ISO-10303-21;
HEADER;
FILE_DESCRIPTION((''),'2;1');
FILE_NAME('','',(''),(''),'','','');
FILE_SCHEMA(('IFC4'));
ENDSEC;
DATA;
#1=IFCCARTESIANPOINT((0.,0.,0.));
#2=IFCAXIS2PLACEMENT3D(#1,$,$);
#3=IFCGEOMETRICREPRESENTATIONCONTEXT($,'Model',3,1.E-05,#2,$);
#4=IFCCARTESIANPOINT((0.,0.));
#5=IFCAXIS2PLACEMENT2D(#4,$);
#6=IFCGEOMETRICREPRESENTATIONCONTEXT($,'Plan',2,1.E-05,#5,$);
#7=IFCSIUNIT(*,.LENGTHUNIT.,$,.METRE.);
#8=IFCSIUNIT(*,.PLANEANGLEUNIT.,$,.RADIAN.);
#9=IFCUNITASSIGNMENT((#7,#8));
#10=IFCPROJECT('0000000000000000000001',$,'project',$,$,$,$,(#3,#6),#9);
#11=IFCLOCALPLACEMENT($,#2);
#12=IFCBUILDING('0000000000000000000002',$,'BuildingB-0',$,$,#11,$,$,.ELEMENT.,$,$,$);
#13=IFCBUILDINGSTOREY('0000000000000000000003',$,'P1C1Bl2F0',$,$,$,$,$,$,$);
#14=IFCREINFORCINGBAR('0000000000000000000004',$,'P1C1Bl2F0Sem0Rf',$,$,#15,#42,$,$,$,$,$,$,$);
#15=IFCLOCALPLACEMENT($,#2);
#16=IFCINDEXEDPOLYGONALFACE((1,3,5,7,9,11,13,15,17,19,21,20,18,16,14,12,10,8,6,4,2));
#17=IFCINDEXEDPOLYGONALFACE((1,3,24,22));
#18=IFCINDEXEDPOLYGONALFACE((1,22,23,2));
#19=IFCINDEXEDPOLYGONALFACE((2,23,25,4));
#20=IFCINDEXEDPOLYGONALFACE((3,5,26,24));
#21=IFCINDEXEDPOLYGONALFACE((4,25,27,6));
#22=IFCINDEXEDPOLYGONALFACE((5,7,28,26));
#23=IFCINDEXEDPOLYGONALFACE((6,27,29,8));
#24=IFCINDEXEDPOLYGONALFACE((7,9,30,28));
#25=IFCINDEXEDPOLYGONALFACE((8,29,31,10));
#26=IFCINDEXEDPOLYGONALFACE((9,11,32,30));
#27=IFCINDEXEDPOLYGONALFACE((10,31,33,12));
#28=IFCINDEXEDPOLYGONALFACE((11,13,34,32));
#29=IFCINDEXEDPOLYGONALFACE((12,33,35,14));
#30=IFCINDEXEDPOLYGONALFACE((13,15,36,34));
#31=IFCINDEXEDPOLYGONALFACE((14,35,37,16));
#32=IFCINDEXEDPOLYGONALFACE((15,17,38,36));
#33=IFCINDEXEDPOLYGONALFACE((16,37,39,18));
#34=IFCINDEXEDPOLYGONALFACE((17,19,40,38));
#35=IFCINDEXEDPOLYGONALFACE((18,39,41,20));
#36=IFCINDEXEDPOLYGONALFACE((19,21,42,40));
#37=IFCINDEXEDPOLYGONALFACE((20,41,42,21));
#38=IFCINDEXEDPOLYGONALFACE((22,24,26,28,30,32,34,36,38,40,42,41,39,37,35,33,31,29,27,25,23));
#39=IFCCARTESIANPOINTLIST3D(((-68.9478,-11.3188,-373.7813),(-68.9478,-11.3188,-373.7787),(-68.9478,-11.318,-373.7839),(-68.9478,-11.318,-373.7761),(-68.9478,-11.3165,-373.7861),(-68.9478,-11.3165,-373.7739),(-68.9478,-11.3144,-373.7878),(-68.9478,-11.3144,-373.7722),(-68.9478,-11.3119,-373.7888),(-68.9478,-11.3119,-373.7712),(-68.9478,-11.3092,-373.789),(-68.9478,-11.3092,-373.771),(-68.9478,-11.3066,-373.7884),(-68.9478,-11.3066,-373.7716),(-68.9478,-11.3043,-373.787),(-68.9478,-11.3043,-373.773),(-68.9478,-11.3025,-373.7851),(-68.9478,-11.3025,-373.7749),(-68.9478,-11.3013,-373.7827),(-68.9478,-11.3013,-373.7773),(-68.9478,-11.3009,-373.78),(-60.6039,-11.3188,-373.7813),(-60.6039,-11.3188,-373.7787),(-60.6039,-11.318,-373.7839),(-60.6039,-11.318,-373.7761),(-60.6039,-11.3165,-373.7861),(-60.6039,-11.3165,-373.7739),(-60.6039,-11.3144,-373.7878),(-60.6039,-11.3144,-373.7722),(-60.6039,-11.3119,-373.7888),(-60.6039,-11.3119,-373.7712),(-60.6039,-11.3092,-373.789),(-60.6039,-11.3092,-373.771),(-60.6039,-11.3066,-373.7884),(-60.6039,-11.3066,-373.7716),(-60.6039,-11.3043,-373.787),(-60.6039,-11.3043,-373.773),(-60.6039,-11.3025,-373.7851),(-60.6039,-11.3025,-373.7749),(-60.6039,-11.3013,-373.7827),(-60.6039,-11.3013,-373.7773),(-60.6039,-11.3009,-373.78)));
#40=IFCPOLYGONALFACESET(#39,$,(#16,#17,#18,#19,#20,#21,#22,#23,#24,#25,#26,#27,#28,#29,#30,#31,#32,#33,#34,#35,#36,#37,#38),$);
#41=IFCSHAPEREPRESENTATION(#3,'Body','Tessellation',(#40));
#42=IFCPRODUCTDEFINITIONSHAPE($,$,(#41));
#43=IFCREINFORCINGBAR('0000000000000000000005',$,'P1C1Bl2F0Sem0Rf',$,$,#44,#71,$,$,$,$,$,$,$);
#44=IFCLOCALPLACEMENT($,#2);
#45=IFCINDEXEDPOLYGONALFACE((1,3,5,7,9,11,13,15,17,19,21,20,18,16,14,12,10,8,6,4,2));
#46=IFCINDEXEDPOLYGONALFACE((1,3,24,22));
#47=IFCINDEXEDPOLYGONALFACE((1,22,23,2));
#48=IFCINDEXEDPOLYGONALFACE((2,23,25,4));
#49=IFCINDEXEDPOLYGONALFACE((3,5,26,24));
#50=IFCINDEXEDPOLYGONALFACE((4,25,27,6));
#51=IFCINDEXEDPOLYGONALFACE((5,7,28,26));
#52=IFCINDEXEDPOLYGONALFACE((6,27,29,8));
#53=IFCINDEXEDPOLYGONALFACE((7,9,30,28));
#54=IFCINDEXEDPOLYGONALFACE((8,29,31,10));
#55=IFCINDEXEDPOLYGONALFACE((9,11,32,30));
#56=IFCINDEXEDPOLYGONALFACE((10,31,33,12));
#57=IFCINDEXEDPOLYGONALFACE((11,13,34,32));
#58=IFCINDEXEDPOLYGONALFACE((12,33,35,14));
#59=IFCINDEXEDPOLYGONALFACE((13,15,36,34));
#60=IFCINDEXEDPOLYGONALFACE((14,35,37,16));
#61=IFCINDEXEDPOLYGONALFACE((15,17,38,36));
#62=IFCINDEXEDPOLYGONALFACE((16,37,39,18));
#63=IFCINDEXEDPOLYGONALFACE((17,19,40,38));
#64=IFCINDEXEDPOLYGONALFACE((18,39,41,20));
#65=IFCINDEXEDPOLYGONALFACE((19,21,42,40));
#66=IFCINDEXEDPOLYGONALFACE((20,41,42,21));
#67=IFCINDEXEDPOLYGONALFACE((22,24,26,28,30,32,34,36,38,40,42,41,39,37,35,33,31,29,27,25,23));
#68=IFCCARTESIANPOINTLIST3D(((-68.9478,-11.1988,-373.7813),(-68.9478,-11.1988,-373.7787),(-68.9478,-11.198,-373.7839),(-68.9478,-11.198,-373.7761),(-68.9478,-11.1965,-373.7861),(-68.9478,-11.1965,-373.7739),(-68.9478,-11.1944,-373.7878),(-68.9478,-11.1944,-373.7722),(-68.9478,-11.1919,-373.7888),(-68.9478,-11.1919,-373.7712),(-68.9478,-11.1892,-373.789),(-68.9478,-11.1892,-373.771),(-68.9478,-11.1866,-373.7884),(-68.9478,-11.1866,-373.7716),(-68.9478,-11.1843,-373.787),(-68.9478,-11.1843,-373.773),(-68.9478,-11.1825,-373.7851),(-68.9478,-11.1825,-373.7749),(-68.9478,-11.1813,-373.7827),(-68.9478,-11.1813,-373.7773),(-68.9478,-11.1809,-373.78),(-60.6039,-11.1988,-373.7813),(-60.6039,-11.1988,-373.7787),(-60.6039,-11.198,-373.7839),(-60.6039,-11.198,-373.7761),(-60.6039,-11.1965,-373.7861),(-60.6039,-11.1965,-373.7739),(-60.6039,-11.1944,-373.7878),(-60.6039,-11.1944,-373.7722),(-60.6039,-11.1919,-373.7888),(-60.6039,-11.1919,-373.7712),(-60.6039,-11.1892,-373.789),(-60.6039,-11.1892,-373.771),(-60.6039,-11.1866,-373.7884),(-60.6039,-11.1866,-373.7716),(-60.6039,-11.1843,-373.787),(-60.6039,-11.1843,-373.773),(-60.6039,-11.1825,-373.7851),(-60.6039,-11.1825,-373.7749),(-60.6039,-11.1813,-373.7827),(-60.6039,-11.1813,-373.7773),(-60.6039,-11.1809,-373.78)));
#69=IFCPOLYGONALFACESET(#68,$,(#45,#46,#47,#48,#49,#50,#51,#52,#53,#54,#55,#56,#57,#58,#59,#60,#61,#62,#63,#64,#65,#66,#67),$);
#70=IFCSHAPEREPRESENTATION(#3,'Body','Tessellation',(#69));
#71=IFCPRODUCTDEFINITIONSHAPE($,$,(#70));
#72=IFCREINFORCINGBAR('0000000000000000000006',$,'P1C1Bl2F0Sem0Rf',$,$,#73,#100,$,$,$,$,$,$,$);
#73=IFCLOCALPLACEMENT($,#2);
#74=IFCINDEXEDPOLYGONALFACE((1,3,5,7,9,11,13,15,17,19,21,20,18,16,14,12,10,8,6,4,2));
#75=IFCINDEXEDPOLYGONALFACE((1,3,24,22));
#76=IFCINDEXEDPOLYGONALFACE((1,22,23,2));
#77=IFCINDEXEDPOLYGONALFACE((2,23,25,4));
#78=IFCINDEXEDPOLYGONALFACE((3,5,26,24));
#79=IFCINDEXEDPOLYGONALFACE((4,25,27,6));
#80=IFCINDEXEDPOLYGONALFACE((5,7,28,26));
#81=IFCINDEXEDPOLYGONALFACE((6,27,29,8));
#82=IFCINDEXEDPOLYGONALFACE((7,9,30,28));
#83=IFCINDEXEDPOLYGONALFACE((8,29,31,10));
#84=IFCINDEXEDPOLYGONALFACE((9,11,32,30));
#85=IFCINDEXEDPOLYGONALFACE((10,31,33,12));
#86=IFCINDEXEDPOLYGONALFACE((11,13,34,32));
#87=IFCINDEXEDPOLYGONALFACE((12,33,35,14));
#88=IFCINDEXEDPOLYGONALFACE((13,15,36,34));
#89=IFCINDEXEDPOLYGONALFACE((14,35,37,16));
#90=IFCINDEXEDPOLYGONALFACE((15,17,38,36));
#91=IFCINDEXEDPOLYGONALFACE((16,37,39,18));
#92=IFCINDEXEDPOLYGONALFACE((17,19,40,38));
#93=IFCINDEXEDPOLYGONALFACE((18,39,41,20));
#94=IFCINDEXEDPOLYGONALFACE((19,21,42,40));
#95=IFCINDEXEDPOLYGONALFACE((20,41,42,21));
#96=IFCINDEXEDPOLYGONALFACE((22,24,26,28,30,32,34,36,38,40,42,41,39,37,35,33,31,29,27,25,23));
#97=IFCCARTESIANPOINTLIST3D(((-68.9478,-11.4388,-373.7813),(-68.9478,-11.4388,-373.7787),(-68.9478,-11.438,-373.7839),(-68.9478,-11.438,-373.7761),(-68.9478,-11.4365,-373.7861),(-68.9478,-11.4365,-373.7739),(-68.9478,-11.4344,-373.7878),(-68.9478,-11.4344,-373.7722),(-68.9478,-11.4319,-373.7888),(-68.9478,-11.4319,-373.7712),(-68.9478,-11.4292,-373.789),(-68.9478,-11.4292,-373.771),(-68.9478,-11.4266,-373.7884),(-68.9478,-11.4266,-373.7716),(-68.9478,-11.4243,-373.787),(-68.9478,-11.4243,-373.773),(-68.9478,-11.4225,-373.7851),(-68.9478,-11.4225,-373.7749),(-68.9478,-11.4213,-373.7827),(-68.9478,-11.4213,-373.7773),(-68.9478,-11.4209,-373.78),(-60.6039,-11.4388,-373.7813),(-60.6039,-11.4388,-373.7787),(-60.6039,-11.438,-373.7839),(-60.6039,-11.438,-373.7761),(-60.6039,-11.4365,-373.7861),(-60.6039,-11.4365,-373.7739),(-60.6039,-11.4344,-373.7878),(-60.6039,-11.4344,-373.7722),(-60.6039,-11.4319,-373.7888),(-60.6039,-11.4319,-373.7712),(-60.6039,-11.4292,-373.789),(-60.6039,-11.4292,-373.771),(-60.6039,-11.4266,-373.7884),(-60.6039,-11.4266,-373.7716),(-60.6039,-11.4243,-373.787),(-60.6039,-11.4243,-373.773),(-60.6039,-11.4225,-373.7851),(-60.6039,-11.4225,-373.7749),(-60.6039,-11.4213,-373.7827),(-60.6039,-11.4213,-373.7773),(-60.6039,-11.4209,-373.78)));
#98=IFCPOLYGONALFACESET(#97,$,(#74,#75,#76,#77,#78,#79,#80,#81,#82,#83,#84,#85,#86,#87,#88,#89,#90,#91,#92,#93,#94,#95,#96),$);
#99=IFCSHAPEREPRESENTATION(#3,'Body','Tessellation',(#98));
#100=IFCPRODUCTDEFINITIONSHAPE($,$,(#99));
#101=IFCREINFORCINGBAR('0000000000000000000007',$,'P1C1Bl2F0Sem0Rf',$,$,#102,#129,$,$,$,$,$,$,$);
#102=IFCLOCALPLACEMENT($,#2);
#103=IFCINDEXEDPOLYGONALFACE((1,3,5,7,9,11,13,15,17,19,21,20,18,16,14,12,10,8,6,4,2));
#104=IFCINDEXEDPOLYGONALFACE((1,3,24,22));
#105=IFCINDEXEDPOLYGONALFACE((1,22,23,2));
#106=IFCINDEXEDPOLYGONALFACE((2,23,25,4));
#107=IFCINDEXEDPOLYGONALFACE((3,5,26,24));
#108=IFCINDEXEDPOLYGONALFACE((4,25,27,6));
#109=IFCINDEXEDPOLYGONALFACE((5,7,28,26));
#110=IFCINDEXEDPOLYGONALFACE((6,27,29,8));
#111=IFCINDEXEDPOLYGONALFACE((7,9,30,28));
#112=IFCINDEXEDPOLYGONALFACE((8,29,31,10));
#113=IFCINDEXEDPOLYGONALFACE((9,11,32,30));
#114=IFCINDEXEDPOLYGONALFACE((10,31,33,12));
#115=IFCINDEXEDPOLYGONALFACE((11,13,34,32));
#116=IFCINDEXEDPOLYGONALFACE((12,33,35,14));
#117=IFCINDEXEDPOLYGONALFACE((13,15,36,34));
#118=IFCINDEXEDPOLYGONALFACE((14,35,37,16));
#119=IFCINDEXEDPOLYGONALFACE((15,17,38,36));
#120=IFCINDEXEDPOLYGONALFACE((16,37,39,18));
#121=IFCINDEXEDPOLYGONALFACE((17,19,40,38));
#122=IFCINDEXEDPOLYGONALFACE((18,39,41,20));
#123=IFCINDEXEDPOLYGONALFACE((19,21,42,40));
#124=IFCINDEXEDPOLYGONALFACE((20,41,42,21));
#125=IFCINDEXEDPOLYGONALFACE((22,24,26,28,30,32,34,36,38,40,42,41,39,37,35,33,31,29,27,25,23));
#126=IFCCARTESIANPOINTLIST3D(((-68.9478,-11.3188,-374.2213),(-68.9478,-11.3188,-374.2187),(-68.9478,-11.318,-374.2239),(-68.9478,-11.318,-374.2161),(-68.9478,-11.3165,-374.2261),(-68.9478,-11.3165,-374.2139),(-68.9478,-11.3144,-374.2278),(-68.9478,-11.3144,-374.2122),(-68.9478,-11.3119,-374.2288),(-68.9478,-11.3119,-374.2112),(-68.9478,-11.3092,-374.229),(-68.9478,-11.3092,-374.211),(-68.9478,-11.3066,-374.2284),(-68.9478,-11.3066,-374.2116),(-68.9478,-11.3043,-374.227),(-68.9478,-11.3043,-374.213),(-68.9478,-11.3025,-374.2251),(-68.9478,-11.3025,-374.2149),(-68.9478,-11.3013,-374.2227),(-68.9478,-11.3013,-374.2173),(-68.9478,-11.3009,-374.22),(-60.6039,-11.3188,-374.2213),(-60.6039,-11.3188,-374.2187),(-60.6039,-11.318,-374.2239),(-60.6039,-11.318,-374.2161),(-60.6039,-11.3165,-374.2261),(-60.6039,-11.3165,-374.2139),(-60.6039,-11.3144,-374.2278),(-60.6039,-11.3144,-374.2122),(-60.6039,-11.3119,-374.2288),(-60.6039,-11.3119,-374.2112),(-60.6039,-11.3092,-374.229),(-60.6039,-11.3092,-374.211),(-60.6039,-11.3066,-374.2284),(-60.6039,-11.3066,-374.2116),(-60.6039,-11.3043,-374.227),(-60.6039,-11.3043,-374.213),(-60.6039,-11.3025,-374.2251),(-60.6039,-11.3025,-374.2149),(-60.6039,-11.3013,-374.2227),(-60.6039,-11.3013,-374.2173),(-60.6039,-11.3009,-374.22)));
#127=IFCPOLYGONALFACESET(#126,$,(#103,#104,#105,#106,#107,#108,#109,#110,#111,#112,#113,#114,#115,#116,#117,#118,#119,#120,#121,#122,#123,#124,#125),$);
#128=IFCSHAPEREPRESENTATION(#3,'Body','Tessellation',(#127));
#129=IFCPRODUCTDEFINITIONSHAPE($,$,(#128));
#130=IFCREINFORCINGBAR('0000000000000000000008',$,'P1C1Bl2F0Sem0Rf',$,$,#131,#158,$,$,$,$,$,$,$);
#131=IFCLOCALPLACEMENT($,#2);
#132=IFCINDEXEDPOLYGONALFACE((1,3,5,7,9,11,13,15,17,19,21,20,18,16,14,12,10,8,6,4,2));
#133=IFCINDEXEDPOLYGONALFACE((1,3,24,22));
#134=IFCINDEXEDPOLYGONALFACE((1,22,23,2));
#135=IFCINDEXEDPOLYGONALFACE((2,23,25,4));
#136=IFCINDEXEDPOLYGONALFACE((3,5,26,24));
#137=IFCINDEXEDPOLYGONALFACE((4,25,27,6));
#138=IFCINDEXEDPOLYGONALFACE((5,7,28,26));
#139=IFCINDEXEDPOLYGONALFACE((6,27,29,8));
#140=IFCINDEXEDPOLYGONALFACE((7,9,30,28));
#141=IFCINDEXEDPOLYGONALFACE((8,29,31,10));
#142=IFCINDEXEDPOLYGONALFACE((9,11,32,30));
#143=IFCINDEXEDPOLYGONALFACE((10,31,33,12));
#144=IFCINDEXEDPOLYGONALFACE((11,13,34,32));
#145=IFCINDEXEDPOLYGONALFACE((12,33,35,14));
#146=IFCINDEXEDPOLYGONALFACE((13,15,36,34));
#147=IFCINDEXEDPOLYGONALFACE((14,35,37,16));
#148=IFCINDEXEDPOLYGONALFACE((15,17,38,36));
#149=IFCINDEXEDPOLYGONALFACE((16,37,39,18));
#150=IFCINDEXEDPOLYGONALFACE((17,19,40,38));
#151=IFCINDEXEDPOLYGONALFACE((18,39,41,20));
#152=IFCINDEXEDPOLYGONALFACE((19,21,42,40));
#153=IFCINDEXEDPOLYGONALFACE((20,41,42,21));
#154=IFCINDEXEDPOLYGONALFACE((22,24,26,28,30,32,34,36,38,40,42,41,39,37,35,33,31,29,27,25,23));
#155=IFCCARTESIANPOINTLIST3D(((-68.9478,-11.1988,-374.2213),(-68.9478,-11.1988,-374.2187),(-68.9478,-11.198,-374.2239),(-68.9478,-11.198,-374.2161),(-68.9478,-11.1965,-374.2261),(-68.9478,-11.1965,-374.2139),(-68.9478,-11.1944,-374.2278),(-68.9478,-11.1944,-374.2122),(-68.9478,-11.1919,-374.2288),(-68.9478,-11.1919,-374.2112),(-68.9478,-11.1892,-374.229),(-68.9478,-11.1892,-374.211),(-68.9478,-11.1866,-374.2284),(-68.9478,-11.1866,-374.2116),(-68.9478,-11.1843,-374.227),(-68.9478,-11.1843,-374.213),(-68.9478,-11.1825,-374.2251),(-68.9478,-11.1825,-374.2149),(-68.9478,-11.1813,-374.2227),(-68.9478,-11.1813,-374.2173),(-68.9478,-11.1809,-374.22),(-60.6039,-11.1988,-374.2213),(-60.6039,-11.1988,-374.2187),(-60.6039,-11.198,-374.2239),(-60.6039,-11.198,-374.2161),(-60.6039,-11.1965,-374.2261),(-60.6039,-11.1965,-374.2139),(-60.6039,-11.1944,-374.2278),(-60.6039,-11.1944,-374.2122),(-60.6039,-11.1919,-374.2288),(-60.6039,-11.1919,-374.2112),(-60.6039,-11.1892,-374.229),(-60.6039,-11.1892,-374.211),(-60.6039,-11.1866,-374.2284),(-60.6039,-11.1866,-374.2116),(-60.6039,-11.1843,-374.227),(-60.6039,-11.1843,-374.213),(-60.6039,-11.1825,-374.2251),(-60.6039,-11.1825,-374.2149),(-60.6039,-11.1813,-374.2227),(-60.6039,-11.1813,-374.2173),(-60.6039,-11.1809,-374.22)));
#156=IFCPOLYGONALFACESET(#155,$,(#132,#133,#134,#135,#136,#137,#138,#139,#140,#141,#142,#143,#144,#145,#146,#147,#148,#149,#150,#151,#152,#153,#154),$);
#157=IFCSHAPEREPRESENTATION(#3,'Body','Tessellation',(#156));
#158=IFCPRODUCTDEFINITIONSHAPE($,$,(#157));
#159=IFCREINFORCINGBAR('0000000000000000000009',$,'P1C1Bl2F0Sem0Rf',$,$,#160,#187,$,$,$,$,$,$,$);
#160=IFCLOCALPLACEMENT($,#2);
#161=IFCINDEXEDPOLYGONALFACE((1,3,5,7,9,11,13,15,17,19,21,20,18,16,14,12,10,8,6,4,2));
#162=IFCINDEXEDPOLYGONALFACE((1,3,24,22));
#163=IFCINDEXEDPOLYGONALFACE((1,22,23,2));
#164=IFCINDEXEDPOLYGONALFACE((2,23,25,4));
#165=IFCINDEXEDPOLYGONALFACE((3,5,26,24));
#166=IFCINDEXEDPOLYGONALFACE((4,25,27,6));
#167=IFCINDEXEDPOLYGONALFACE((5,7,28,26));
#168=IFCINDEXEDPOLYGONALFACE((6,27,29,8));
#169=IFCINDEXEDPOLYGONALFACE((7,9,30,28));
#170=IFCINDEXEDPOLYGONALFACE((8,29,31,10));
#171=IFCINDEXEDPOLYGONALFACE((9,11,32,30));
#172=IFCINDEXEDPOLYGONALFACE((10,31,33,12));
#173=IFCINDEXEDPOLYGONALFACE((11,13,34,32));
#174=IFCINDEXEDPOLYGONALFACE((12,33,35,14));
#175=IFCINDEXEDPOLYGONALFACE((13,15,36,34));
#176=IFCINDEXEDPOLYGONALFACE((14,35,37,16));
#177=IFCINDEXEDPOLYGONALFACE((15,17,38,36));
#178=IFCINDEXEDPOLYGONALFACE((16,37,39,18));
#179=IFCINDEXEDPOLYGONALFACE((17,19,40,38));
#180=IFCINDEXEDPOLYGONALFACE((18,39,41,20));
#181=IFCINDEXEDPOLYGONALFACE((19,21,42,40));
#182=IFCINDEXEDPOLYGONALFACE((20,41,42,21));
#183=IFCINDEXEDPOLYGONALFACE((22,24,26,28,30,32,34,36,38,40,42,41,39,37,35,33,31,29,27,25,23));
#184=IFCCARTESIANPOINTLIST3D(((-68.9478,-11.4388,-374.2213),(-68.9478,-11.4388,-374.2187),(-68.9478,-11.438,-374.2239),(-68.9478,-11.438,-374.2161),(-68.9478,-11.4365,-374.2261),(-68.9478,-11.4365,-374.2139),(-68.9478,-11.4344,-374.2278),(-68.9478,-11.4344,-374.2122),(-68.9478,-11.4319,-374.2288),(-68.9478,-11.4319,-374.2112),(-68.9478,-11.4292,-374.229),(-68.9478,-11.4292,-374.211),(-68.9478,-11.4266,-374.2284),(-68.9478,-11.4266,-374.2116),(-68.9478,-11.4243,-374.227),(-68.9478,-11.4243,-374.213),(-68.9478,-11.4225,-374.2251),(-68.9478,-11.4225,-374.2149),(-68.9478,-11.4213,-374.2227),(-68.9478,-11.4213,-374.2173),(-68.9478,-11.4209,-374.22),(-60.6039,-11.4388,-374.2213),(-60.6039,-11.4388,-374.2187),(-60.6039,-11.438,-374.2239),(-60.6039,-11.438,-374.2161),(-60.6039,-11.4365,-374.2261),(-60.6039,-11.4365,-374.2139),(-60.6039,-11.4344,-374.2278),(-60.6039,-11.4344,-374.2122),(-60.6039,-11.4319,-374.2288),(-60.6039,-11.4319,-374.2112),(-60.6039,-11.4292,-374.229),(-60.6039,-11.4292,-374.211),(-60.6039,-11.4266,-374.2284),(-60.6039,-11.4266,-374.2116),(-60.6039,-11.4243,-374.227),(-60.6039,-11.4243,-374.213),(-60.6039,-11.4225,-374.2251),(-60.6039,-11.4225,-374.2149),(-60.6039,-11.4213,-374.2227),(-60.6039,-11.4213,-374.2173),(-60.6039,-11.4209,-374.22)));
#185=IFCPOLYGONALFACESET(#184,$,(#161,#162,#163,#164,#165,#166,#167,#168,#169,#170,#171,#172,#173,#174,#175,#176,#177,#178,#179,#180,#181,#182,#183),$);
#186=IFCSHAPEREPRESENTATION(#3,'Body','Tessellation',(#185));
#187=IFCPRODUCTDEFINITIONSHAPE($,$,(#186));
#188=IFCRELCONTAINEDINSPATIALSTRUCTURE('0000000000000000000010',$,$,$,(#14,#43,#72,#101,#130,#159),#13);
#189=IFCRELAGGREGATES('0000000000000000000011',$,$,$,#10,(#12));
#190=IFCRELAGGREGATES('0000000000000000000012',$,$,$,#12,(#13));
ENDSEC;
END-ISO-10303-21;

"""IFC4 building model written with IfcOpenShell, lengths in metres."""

from ifc_helpers import new_model, entity, si_unit, origin, origin_2d, place, context, project, spatial, element, save


model = new_model("IFC4")

# Units and contexts
model_context = context("Model", 3, precision=1e-05, world=origin())
plan_context = context("Plan", 2, precision=1e-05, world=origin_2d())
ifc_project = project(units=[si_unit("LENGTHUNIT", "METRE"), si_unit("PLANEANGLEUNIT", "RADIAN")], contexts=[model_context, plan_context])

# Building, storey
building_placement = place(None, origin())
building = spatial("IfcBuilding", under=ifc_project, at=building_placement, Name="BuildingB-0", CompositionType="ELEMENT")
storey = spatial("IfcBuildingStorey", under=building, Name="P1C1Bl2F0")

# Reinforcing bars
element("IfcReinforcingBar", 1, inside=storey, Name="P1C1Bl2F0Sem0Rf", context=model_context, shape_type="SweptSolid", body=[
    entity("IfcSurfaceCurveSweptAreaSolid", entity("IfcCircleProfileDef", "AREA", None, None, 0.009), None, entity("IfcPolyline", [entity("IfcCartesianPoint", [60.6039, 11.3099, 373.78]), entity("IfcCartesianPoint", [68.9478, 11.3099, 373.78])]), None, None, entity("IfcPlane", entity("IfcAxis2Placement3D", entity("IfcCartesianPoint", [60.6039, 11.3099, 373.78]), entity("IfcDirection", [0.0, 0.0, 1.0]), entity("IfcDirection", [1.0, 0.0, 0.0])))),
])
element("IfcReinforcingBar", 2, inside=storey, Name="P1C1Bl2F0Sem0Rf", context=model_context, shape_type="SweptSolid", body=[
    entity("IfcSurfaceCurveSweptAreaSolid", entity("IfcCircleProfileDef", "AREA", None, None, 0.009), None, entity("IfcPolyline", [entity("IfcCartesianPoint", [60.6039, 11.1899, 373.78]), entity("IfcCartesianPoint", [68.9478, 11.1899, 373.78])]), None, None, entity("IfcPlane", entity("IfcAxis2Placement3D", entity("IfcCartesianPoint", [60.6039, 11.1899, 373.78]), entity("IfcDirection", [0.0, 0.0, 1.0]), entity("IfcDirection", [1.0, 0.0, 0.0])))),
])
element("IfcReinforcingBar", 3, inside=storey, Name="P1C1Bl2F0Sem0Rf", context=model_context, shape_type="SweptSolid", body=[
    entity("IfcSurfaceCurveSweptAreaSolid", entity("IfcCircleProfileDef", "AREA", None, None, 0.009), None, entity("IfcPolyline", [entity("IfcCartesianPoint", [60.6039, 11.4299, 373.78]), entity("IfcCartesianPoint", [68.9478, 11.4299, 373.78])]), None, None, entity("IfcPlane", entity("IfcAxis2Placement3D", entity("IfcCartesianPoint", [60.6039, 11.4299, 373.78]), entity("IfcDirection", [0.0, 0.0, 1.0]), entity("IfcDirection", [1.0, 0.0, 0.0])))),
])
element("IfcReinforcingBar", 4, inside=storey, Name="P1C1Bl2F0Sem0Rf", context=model_context, shape_type="SweptSolid", body=[
    entity("IfcSurfaceCurveSweptAreaSolid", entity("IfcCircleProfileDef", "AREA", None, None, 0.009), None, entity("IfcPolyline", [entity("IfcCartesianPoint", [60.6039, 11.3099, 374.22]), entity("IfcCartesianPoint", [68.9478, 11.3099, 374.22])]), None, None, entity("IfcPlane", entity("IfcAxis2Placement3D", entity("IfcCartesianPoint", [60.6039, 11.3099, 374.22]), entity("IfcDirection", [0.0, 0.0, 1.0]), entity("IfcDirection", [1.0, 0.0, 0.0])))),
])
element("IfcReinforcingBar", 5, inside=storey, Name="P1C1Bl2F0Sem0Rf", context=model_context, shape_type="SweptSolid", body=[
    entity("IfcSurfaceCurveSweptAreaSolid", entity("IfcCircleProfileDef", "AREA", None, None, 0.009), None, entity("IfcPolyline", [entity("IfcCartesianPoint", [60.6039, 11.1899, 374.22]), entity("IfcCartesianPoint", [68.9478, 11.1899, 374.22])]), None, None, entity("IfcPlane", entity("IfcAxis2Placement3D", entity("IfcCartesianPoint", [60.6039, 11.1899, 374.22]), entity("IfcDirection", [0.0, 0.0, 1.0]), entity("IfcDirection", [1.0, 0.0, 0.0])))),
])
element("IfcReinforcingBar", 6, inside=storey, Name="P1C1Bl2F0Sem0Rf", context=model_context, shape_type="SweptSolid", body=[
    entity("IfcSurfaceCurveSweptAreaSolid", entity("IfcCircleProfileDef", "AREA", None, None, 0.009), None, entity("IfcPolyline", [entity("IfcCartesianPoint", [60.6039, 11.4299, 374.22]), entity("IfcCartesianPoint", [68.9478, 11.4299, 374.22])]), None, None, entity("IfcPlane", entity("IfcAxis2Placement3D", entity("IfcCartesianPoint", [60.6039, 11.4299, 374.22]), entity("IfcDirection", [0.0, 0.0, 1.0]), entity("IfcDirection", [1.0, 0.0, 0.0])))),
])

save(model, "model.ifc")
